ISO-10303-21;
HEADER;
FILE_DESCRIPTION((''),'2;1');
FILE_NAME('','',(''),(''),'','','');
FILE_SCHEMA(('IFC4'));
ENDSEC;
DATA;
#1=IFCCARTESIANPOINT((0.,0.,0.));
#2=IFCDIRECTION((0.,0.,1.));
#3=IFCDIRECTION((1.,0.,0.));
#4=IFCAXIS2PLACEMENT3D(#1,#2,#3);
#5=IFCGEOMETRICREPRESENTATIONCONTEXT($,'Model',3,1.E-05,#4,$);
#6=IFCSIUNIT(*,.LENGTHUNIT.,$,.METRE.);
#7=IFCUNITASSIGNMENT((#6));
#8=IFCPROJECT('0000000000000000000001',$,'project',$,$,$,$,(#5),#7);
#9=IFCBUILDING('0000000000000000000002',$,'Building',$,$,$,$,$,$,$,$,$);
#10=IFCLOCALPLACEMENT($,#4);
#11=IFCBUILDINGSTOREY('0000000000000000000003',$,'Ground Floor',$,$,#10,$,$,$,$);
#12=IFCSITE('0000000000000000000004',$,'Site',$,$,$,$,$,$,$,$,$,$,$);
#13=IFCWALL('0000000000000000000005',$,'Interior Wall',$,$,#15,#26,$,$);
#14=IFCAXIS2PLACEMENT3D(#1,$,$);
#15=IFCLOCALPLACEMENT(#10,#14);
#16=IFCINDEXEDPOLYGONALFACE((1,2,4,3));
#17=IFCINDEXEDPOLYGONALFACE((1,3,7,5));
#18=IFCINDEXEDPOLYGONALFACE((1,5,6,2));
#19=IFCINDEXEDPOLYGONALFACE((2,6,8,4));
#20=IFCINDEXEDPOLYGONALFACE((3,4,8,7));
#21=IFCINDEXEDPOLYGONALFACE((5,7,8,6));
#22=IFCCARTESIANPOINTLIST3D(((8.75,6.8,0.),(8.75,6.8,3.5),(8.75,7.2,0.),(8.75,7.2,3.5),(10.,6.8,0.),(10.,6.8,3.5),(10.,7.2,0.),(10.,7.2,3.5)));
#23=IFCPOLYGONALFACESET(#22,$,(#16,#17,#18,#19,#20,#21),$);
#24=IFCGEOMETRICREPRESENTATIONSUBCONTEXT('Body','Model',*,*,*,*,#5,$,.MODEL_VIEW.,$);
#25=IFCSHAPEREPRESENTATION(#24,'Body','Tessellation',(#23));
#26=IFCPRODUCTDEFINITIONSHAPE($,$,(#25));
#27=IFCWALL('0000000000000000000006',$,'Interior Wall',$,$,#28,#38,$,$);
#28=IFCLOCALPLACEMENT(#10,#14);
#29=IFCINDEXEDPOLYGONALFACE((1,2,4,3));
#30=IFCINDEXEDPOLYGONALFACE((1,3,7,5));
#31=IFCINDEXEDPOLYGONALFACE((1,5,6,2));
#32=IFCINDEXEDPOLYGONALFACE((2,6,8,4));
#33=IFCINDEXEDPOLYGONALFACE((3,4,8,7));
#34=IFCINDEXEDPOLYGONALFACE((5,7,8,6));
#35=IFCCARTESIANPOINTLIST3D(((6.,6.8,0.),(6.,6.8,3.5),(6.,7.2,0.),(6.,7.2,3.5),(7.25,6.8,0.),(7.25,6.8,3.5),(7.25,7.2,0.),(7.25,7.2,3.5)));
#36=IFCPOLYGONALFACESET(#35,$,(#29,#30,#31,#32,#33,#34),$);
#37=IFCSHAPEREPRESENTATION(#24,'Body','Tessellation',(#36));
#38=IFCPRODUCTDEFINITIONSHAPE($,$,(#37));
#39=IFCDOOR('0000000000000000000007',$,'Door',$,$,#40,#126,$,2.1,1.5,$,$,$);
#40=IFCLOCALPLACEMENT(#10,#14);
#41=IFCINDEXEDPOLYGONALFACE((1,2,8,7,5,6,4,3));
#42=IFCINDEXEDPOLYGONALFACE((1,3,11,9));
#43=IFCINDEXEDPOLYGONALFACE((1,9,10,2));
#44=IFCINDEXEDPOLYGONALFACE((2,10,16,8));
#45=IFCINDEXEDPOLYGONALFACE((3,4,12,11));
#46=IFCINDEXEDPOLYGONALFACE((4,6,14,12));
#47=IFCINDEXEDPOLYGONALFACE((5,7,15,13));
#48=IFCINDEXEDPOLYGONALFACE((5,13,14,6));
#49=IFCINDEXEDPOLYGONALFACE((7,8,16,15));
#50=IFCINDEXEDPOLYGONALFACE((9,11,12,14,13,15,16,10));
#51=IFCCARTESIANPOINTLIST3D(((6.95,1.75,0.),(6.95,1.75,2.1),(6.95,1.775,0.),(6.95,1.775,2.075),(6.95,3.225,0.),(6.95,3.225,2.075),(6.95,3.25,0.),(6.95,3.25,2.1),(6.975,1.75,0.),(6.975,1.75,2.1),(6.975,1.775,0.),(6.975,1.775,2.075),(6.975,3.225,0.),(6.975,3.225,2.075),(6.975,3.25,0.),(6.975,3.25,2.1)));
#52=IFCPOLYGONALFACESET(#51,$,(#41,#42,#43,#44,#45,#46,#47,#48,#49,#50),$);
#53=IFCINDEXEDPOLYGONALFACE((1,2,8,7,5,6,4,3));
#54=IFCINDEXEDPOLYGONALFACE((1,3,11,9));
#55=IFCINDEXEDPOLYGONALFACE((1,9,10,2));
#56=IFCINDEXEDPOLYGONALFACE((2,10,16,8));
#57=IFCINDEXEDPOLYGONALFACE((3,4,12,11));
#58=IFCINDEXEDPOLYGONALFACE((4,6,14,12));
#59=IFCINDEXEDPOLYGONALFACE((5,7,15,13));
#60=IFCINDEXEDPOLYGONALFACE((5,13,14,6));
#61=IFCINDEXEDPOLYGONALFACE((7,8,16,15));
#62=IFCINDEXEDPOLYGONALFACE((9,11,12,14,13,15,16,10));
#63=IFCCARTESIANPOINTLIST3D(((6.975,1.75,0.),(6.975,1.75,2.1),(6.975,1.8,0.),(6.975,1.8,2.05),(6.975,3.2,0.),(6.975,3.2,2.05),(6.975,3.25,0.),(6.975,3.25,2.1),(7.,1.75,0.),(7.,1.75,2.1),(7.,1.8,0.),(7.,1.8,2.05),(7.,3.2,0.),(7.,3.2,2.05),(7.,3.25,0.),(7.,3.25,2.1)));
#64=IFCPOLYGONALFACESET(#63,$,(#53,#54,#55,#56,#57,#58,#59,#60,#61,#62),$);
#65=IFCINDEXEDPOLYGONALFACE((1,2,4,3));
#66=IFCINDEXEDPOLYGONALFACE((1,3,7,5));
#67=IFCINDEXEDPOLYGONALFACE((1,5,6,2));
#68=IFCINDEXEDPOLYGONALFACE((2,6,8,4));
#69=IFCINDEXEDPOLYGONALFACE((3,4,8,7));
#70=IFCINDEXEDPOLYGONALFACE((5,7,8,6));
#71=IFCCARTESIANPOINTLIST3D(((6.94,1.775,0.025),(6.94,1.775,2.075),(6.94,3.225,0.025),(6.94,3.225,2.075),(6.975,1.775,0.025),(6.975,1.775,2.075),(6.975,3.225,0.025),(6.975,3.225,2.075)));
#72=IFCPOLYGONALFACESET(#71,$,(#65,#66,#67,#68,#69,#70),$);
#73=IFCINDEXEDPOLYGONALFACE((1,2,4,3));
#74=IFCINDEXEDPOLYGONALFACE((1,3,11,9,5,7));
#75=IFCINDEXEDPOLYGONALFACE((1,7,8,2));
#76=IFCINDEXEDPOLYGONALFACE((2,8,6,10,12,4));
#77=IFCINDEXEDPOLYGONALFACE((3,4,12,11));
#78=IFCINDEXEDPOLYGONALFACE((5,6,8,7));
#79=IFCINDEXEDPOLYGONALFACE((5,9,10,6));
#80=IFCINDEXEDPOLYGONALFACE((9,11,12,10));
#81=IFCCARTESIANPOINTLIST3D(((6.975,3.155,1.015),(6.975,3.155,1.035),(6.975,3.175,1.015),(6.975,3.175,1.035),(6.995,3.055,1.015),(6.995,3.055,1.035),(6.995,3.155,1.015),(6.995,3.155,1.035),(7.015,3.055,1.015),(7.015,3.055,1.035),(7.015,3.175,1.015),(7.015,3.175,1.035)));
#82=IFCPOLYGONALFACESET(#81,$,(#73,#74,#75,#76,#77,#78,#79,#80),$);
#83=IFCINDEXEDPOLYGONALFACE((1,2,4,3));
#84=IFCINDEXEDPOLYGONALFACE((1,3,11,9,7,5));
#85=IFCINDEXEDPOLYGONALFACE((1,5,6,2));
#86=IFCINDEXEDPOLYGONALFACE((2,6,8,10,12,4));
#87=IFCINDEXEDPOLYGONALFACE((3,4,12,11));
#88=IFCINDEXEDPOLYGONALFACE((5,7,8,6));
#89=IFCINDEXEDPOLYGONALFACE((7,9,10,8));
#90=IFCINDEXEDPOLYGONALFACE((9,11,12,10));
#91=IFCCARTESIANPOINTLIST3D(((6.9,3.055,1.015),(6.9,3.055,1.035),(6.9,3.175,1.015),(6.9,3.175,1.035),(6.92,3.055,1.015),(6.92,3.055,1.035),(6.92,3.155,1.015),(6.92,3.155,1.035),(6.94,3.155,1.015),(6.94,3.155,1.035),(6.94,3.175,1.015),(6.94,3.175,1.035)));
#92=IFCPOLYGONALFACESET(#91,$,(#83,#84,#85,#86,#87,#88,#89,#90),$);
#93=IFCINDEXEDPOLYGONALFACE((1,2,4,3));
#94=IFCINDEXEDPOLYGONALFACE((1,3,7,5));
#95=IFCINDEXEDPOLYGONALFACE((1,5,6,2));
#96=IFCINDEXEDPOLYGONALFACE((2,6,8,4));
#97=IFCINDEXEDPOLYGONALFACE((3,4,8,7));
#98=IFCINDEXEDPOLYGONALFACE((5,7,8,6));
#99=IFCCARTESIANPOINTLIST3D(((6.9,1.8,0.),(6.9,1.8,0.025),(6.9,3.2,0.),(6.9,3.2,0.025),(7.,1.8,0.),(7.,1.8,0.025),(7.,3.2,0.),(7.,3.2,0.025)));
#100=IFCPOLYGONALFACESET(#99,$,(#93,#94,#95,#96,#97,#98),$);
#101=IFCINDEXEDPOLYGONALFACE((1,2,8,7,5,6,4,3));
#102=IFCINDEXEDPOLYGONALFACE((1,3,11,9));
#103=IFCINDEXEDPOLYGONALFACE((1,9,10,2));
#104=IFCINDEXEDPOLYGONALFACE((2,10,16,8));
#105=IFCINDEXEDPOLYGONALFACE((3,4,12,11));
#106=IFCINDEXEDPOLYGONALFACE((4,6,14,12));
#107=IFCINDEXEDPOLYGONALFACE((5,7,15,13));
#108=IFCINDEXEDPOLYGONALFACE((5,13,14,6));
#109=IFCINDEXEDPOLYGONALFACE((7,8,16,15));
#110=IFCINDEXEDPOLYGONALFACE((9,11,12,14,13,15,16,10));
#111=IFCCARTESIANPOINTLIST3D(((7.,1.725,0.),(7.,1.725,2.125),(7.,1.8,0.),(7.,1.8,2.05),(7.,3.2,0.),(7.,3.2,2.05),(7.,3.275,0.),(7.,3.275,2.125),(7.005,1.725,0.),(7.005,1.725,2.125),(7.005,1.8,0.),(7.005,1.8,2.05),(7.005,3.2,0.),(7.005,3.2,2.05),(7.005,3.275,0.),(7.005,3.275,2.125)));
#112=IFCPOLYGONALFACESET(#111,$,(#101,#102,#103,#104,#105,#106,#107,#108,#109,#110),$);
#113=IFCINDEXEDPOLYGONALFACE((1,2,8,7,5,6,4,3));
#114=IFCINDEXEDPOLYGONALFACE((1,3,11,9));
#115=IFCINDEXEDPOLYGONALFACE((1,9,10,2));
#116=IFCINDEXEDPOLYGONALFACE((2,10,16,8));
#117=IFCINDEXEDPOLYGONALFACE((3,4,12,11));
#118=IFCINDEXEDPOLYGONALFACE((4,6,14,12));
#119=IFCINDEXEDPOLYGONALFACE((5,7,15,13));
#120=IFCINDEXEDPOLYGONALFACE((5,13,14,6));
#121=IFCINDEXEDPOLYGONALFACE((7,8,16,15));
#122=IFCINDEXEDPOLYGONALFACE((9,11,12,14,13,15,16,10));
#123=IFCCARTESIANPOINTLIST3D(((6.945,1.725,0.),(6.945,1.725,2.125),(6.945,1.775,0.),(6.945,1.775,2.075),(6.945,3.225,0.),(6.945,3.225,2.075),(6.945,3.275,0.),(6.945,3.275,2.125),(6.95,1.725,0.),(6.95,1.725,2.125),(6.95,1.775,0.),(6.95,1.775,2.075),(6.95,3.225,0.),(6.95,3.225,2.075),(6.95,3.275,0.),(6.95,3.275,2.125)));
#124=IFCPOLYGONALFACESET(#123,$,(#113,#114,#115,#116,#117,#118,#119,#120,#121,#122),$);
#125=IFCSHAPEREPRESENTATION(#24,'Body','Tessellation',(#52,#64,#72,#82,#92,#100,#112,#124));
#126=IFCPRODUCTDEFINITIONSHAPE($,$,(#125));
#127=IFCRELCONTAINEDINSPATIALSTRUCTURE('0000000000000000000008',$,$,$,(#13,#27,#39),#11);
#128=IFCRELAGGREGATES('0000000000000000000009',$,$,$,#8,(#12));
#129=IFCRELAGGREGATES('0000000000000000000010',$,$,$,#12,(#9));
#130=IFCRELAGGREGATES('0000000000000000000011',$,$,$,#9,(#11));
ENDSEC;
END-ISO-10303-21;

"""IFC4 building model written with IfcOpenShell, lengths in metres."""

from ifc_helpers import new_model, si_unit, frame, origin_with_axes, place, context, subcontext, project, spatial, line, indexed_curve, outline, extrude, element, save


model = new_model("IFC4")

# Units and contexts
model_context = context("Model", 3, precision=1e-05, world=origin_with_axes())
body_context = subcontext(model_context, "Body", "Model", "MODEL_VIEW")
ifc_project = project(units=[si_unit("LENGTHUNIT", "METRE")], contexts=[model_context])

# Site, building, storey
site = spatial("IfcSite", under=ifc_project, Name="Site")
building = spatial("IfcBuilding", under=site, Name="Building")
storey_placement = place(None, origin_with_axes())
storey = spatial("IfcBuildingStorey", under=building, at=storey_placement, Name="Ground Floor")

# Walls
for number, where, z_axis, x_axis, name in (
    (1, (10.0, 7.0, 0.0), (0.0, 0.0, 1.0), (-1.0, 0.0, 0.0), "Interior Wall"),
    (2, (7.25, 7.0, 0.0), (0.0, 0.0, 1.0), (-1.0, 0.0, 0.0), "Interior Wall"),
):
    element("IfcWall", number, at=place(storey_placement, frame(where, z_axis=z_axis, x_axis=x_axis)), inside=storey, Name=name, context=body_context, shape_type="SweptSolid", body=[
        extrude(outline(indexed_curve([(0.0, 0.0), (0.0, 0.4), (1.25, 0.4), (1.25, 0.0), (0.0, 0.0)], self_intersect=False)), frame((0.0, -0.2, 0.0), z_axis=(0.0, 0.0, 1.0), x_axis=(1.0, 0.0, 0.0)), (0.0, 0.0, 1.0), 3.5),
    ])

# Door
door_1_placement = place(storey_placement, frame((7.0, 1.75, 0.0), z_axis=(0.0, 0.0, 1.0), x_axis=(0.0, 1.0, 0.0)))
element("IfcDoor", 3, at=door_1_placement, inside=storey, Name="Door", OverallHeight=2.1, OverallWidth=1.5, context=body_context, shape_type="SweptSolid", body=[
    extrude(outline(indexed_curve([(0.0, 0.0), (0.0, 2.1), (1.5, 2.1), (1.5, 0.0), (1.475, 0.0), (1.475, 2.075), (0.025, 2.075), (0.025, 0.0)], segments=[line(1, 2, 3, 4, 5, 6, 7, 8, 1)])), frame((0.0, 0.025, 0.0), z_axis=(0.0, -1.0, 0.0), x_axis=(1.0, 0.0, 0.0)), (0.0, 0.0, -1.0), 0.025),
    extrude(outline(indexed_curve([(0.0, 0.0), (0.0, 2.1), (1.5, 2.1), (1.5, 0.0), (1.45, 0.0), (1.45, 2.05), (0.05, 2.05), (0.05, 0.0)], segments=[line(1, 2, 3, 4, 5, 6, 7, 8, 1)])), frame((0.0, 0.0, 0.0), z_axis=(0.0, -1.0, 0.0), x_axis=(1.0, 0.0, 0.0)), (0.0, 0.0, -1.0), 0.025),
    extrude(outline(indexed_curve([(0.0, 0.0), (1.45, 0.0), (1.45, 0.035), (0.0, 0.035)], segments=[line(1, 2, 3, 4, 1)])), frame((0.025, 0.025, 0.025), z_axis=(0.0, 0.0, 1.0), x_axis=(1.0, 0.0, 0.0)), (0.0, 0.0, 1.0), 2.05),
    extrude(outline(indexed_curve([(0.0, 0.0), (0.0, -0.04), (-0.12, -0.04), (-0.12, -0.02), (-0.02, -0.02), (-0.02, 0.0)], segments=[line(1, 2, 3, 4, 5, 6, 1)])), frame((1.425, 0.025, 1.015), z_axis=(0.0, 0.0, 1.0), x_axis=(1.0, 0.0, 0.0)), (0.0, 0.0, 1.0), 0.02),
    extrude(outline(indexed_curve([(0.0, 0.0), (0.0, 0.04), (-0.12, 0.04), (-0.12, 0.02), (-0.02, 0.02), (-0.02, 0.0)], segments=[line(1, 2, 3, 4, 5, 6, 1)])), frame((1.425, 0.06, 1.015), z_axis=(0.0, 0.0, 1.0), x_axis=(1.0, 0.0, 0.0)), (0.0, 0.0, 1.0), 0.02),
    extrude(outline(indexed_curve([(0.0, 0.0), (1.4, 0.0), (1.4, 0.1), (0.0, 0.1)], segments=[line(1, 2, 3, 4, 1)])), frame((0.05, 0.0, 0.0), z_axis=(0.0, 0.0, 1.0), x_axis=(1.0, 0.0, 0.0)), (0.0, 0.0, 1.0), 0.025),
    extrude(outline(indexed_curve([(0.0, 0.0), (0.0, 2.125), (1.55, 2.125), (1.55, 0.0), (1.475, 0.0), (1.475, 2.05), (0.075, 2.05), (0.075, 0.0)], segments=[line(1, 2, 3, 4, 5, 6, 7, 8, 1)])), frame((-0.025, -0.005, 0.0), z_axis=(0.0, -1.0, 0.0), x_axis=(1.0, 0.0, 0.0)), (0.0, 0.0, -1.0), 0.005),
    extrude(outline(indexed_curve([(0.0, 0.0), (0.0, 2.125), (1.55, 2.125), (1.55, 0.0), (1.5, 0.0), (1.5, 2.075), (0.05, 2.075), (0.05, 0.0)], segments=[line(1, 2, 3, 4, 5, 6, 7, 8, 1)])), frame((-0.025, 0.05, 0.0), z_axis=(0.0, -1.0, 0.0), x_axis=(1.0, 0.0, 0.0)), (0.0, 0.0, -1.0), 0.005),
])

save(model, "model.ifc")
